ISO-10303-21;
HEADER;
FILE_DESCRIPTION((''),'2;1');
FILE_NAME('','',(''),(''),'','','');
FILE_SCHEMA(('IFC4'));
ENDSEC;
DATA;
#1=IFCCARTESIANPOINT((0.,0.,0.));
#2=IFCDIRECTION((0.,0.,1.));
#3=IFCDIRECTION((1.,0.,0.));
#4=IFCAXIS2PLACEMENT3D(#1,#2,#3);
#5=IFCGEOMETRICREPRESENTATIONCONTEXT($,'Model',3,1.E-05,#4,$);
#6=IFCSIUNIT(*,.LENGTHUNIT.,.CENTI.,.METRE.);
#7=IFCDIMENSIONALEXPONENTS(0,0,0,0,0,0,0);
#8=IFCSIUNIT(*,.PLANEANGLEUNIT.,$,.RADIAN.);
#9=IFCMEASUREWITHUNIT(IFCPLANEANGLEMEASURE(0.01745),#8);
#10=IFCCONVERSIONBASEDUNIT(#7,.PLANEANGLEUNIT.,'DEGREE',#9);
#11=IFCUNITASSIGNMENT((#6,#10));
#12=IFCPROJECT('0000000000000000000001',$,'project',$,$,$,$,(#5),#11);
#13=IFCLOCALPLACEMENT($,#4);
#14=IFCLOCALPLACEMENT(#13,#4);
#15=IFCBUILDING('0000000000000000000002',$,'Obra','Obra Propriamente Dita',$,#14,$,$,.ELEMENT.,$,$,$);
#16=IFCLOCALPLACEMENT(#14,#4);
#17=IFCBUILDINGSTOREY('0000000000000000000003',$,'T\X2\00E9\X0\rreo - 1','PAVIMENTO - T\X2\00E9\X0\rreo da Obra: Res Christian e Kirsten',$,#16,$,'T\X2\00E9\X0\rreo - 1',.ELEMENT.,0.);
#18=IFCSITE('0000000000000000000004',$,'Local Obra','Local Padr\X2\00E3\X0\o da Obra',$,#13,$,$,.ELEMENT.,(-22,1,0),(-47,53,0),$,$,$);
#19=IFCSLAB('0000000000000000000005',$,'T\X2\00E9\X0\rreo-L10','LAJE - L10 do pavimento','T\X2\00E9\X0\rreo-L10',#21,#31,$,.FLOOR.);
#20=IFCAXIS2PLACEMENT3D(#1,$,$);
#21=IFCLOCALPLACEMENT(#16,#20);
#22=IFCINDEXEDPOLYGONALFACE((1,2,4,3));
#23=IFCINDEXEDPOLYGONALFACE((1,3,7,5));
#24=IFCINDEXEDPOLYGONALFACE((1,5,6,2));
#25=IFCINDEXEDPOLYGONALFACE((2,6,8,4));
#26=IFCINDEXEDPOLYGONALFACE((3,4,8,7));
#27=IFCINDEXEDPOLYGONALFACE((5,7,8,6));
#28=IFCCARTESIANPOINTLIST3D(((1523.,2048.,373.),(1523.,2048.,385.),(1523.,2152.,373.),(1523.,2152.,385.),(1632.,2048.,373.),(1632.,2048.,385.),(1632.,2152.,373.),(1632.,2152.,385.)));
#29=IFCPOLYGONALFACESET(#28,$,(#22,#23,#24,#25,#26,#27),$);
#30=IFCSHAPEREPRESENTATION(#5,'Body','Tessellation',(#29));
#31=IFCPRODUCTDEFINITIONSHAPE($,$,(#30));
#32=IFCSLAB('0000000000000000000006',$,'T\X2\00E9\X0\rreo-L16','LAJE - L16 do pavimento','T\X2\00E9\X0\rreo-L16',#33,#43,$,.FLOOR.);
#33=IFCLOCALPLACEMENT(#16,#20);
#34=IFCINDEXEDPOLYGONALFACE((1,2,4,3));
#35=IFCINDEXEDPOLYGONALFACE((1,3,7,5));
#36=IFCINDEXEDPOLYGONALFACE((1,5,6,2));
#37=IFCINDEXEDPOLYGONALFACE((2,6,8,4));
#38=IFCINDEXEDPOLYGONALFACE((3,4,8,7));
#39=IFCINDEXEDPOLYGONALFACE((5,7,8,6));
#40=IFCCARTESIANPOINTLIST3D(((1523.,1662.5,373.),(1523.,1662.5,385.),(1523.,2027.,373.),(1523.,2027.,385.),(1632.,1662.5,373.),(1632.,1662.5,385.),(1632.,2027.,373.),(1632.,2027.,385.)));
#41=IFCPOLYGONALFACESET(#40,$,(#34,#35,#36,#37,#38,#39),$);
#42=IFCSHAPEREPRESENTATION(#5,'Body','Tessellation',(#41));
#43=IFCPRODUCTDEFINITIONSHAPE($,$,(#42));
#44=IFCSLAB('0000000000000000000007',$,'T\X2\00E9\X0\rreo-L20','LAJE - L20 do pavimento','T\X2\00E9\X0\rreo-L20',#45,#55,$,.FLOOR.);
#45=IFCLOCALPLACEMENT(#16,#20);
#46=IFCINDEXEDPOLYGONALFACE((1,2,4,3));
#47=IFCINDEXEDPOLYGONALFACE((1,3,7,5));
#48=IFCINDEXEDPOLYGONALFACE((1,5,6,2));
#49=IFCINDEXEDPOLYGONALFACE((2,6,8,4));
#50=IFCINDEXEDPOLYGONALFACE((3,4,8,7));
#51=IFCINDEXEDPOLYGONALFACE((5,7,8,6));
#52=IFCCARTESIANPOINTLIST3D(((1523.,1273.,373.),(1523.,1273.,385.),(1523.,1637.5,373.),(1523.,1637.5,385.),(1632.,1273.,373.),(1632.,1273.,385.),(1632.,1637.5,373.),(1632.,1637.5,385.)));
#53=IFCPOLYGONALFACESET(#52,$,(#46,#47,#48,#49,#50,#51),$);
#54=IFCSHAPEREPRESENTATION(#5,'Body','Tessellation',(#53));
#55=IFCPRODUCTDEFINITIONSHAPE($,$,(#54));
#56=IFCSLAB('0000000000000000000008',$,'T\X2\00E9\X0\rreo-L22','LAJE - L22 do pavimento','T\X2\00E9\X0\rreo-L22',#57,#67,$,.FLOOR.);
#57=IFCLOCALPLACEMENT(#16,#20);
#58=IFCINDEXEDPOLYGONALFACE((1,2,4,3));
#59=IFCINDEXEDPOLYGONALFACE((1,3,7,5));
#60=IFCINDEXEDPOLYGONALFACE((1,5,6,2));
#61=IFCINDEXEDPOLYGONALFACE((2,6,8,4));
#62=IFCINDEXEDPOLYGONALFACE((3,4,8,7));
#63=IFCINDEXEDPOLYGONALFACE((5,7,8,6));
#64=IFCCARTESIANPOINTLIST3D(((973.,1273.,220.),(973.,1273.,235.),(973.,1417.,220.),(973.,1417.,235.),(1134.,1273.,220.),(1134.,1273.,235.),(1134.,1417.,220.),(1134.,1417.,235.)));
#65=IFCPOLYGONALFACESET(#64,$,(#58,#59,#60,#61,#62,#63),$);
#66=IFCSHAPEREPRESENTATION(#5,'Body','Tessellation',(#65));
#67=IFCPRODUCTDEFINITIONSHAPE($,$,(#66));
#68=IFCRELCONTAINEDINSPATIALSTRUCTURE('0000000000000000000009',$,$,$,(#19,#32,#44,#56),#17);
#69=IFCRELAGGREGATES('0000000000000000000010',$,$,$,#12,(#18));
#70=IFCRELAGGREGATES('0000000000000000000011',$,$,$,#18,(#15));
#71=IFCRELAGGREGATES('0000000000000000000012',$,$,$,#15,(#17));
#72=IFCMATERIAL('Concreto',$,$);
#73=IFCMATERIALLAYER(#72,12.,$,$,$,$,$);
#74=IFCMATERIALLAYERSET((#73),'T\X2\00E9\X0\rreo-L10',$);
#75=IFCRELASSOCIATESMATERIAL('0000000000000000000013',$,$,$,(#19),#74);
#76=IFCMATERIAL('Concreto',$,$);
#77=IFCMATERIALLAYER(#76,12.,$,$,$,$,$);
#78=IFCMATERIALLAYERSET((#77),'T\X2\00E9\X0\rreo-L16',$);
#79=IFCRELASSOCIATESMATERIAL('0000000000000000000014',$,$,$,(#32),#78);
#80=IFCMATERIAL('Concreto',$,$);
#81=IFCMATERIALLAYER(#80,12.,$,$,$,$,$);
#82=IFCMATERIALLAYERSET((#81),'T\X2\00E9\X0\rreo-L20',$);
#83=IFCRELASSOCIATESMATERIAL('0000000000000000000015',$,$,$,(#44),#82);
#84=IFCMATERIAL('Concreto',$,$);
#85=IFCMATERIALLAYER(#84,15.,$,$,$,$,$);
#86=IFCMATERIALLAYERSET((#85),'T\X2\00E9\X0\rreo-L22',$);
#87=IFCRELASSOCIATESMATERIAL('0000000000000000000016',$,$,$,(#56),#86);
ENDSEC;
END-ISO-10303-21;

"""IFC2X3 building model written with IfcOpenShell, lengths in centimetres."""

from ifc_helpers import new_model, entity, si_unit, converted_unit, frame, origin_with_axes, place, context, project, spatial, polyline, outline, extrude, material, layer, layer_set, layer_usage, element, save


model = new_model("IFC2X3")

# Units and contexts
model_context = context("Model", 3, precision=1e-05, world=origin_with_axes())
ifc_project = project(units=[si_unit("LENGTHUNIT", "METRE", prefix="CENTI"), converted_unit("PLANEANGLEUNIT", "DEGREE", entity("IfcPlaneAngleMeasure", 0.01745), si_unit("PLANEANGLEUNIT", "RADIAN"), dimensions=[0, 0, 0, 0, 0, 0, 0])], contexts=[model_context])

# Site, building, storey
site_placement = place(None, origin_with_axes())
site = spatial("IfcSite", under=ifc_project, at=site_placement, Name="Local Obra", Description="Local Padrão da Obra", CompositionType="ELEMENT", RefLatitude=(-22, 1, 0), RefLongitude=(-47, 53, 0))
building_placement = place(site_placement, origin_with_axes())
building = spatial("IfcBuilding", under=site, at=building_placement, Name="Obra", Description="Obra Propriamente Dita", CompositionType="ELEMENT")
storey_placement = place(building_placement, origin_with_axes())
storey = spatial("IfcBuildingStorey", under=building, at=storey_placement, Name="Térreo - 1", Description="PAVIMENTO - Térreo da Obra: Res Christian e Kirsten", LongName="Térreo - 1", CompositionType="ELEMENT", Elevation=0.0)

# Slabs
ifc_material_1 = material(Name="Concreto")
ifc_layer_1 = layer(ifc_material_1, 12.0)
ifc_layer_set_1 = layer_set([ifc_layer_1], Name="Térreo-L10")
ifc_layer_usage_1 = layer_usage(ifc_layer_set_1, "AXIS3", "POSITIVE", 0.0)
slab_1_placement = place(storey_placement, frame((1632.0, 2048.0, 373.0), z_axis=(0.0, 0.0, 1.0), x_axis=(1.0, 0.0, 0.0)))
element("IfcSlab", 1, at=slab_1_placement, inside=storey, material=ifc_layer_usage_1, Name="Térreo-L10", Description="LAJE - L10 do pavimento", ObjectType="Térreo-L10", PredefinedType="FLOOR", context=model_context, shape_type="SweptSolid", body=[
    extrude(outline(polyline([(0.0, 104.0), (-109.0, 104.0), (-109.0, 0.0), (0.0, 0.0), (0.0, 104.0)])), origin_with_axes(), (0.0, 0.0, 1.0), 12.0),
])
ifc_material_2 = material(Name="Concreto")
ifc_layer_2 = layer(ifc_material_2, 12.0)
ifc_layer_set_2 = layer_set([ifc_layer_2], Name="Térreo-L16")
ifc_layer_usage_2 = layer_usage(ifc_layer_set_2, "AXIS3", "POSITIVE", 0.0)
slab_2_placement = place(storey_placement, frame((1632.0, 1662.5, 373.0), z_axis=(0.0, 0.0, 1.0), x_axis=(1.0, 0.0, 0.0)))
element("IfcSlab", 2, at=slab_2_placement, inside=storey, material=ifc_layer_usage_2, Name="Térreo-L16", Description="LAJE - L16 do pavimento", ObjectType="Térreo-L16", PredefinedType="FLOOR", context=model_context, shape_type="SweptSolid", body=[
    extrude(outline(polyline([(0.0, 364.5), (-109.0, 364.5), (-109.0, 0.0), (0.0, 0.0), (0.0, 364.5)])), origin_with_axes(), (0.0, 0.0, 1.0), 12.0),
])
ifc_material_3 = material(Name="Concreto")
ifc_layer_3 = layer(ifc_material_3, 12.0)
ifc_layer_set_3 = layer_set([ifc_layer_3], Name="Térreo-L20")
ifc_layer_usage_3 = layer_usage(ifc_layer_set_3, "AXIS3", "POSITIVE", 0.0)
slab_3_placement = place(storey_placement, frame((1632.0, 1273.0, 373.0), z_axis=(0.0, 0.0, 1.0), x_axis=(1.0, 0.0, 0.0)))
element("IfcSlab", 3, at=slab_3_placement, inside=storey, material=ifc_layer_usage_3, Name="Térreo-L20", Description="LAJE - L20 do pavimento", ObjectType="Térreo-L20", PredefinedType="FLOOR", context=model_context, shape_type="SweptSolid", body=[
    extrude(outline(polyline([(0.0, 364.5), (-109.0, 364.5), (-109.0, 0.0), (0.0, 0.0), (0.0, 364.5)])), origin_with_axes(), (0.0, 0.0, 1.0), 12.0),
])
ifc_material_4 = material(Name="Concreto")
ifc_layer_4 = layer(ifc_material_4, 15.0)
ifc_layer_set_4 = layer_set([ifc_layer_4], Name="Térreo-L22")
ifc_layer_usage_4 = layer_usage(ifc_layer_set_4, "AXIS3", "POSITIVE", 0.0)
slab_4_placement = place(storey_placement, frame((1134.0, 1273.0, 220.0), z_axis=(0.0, 0.0, 1.0), x_axis=(1.0, 0.0, 0.0)))
element("IfcSlab", 4, at=slab_4_placement, inside=storey, material=ifc_layer_usage_4, Name="Térreo-L22", Description="LAJE - L22 do pavimento", ObjectType="Térreo-L22", PredefinedType="FLOOR", context=model_context, shape_type="SweptSolid", body=[
    extrude(outline(polyline([(0.0, 144.0), (-161.0, 144.0), (-161.0, 0.0), (0.0, 0.0), (0.0, 144.0)])), origin_with_axes(), (0.0, 0.0, 1.0), 15.0),
])

save(model, "model.ifc")
